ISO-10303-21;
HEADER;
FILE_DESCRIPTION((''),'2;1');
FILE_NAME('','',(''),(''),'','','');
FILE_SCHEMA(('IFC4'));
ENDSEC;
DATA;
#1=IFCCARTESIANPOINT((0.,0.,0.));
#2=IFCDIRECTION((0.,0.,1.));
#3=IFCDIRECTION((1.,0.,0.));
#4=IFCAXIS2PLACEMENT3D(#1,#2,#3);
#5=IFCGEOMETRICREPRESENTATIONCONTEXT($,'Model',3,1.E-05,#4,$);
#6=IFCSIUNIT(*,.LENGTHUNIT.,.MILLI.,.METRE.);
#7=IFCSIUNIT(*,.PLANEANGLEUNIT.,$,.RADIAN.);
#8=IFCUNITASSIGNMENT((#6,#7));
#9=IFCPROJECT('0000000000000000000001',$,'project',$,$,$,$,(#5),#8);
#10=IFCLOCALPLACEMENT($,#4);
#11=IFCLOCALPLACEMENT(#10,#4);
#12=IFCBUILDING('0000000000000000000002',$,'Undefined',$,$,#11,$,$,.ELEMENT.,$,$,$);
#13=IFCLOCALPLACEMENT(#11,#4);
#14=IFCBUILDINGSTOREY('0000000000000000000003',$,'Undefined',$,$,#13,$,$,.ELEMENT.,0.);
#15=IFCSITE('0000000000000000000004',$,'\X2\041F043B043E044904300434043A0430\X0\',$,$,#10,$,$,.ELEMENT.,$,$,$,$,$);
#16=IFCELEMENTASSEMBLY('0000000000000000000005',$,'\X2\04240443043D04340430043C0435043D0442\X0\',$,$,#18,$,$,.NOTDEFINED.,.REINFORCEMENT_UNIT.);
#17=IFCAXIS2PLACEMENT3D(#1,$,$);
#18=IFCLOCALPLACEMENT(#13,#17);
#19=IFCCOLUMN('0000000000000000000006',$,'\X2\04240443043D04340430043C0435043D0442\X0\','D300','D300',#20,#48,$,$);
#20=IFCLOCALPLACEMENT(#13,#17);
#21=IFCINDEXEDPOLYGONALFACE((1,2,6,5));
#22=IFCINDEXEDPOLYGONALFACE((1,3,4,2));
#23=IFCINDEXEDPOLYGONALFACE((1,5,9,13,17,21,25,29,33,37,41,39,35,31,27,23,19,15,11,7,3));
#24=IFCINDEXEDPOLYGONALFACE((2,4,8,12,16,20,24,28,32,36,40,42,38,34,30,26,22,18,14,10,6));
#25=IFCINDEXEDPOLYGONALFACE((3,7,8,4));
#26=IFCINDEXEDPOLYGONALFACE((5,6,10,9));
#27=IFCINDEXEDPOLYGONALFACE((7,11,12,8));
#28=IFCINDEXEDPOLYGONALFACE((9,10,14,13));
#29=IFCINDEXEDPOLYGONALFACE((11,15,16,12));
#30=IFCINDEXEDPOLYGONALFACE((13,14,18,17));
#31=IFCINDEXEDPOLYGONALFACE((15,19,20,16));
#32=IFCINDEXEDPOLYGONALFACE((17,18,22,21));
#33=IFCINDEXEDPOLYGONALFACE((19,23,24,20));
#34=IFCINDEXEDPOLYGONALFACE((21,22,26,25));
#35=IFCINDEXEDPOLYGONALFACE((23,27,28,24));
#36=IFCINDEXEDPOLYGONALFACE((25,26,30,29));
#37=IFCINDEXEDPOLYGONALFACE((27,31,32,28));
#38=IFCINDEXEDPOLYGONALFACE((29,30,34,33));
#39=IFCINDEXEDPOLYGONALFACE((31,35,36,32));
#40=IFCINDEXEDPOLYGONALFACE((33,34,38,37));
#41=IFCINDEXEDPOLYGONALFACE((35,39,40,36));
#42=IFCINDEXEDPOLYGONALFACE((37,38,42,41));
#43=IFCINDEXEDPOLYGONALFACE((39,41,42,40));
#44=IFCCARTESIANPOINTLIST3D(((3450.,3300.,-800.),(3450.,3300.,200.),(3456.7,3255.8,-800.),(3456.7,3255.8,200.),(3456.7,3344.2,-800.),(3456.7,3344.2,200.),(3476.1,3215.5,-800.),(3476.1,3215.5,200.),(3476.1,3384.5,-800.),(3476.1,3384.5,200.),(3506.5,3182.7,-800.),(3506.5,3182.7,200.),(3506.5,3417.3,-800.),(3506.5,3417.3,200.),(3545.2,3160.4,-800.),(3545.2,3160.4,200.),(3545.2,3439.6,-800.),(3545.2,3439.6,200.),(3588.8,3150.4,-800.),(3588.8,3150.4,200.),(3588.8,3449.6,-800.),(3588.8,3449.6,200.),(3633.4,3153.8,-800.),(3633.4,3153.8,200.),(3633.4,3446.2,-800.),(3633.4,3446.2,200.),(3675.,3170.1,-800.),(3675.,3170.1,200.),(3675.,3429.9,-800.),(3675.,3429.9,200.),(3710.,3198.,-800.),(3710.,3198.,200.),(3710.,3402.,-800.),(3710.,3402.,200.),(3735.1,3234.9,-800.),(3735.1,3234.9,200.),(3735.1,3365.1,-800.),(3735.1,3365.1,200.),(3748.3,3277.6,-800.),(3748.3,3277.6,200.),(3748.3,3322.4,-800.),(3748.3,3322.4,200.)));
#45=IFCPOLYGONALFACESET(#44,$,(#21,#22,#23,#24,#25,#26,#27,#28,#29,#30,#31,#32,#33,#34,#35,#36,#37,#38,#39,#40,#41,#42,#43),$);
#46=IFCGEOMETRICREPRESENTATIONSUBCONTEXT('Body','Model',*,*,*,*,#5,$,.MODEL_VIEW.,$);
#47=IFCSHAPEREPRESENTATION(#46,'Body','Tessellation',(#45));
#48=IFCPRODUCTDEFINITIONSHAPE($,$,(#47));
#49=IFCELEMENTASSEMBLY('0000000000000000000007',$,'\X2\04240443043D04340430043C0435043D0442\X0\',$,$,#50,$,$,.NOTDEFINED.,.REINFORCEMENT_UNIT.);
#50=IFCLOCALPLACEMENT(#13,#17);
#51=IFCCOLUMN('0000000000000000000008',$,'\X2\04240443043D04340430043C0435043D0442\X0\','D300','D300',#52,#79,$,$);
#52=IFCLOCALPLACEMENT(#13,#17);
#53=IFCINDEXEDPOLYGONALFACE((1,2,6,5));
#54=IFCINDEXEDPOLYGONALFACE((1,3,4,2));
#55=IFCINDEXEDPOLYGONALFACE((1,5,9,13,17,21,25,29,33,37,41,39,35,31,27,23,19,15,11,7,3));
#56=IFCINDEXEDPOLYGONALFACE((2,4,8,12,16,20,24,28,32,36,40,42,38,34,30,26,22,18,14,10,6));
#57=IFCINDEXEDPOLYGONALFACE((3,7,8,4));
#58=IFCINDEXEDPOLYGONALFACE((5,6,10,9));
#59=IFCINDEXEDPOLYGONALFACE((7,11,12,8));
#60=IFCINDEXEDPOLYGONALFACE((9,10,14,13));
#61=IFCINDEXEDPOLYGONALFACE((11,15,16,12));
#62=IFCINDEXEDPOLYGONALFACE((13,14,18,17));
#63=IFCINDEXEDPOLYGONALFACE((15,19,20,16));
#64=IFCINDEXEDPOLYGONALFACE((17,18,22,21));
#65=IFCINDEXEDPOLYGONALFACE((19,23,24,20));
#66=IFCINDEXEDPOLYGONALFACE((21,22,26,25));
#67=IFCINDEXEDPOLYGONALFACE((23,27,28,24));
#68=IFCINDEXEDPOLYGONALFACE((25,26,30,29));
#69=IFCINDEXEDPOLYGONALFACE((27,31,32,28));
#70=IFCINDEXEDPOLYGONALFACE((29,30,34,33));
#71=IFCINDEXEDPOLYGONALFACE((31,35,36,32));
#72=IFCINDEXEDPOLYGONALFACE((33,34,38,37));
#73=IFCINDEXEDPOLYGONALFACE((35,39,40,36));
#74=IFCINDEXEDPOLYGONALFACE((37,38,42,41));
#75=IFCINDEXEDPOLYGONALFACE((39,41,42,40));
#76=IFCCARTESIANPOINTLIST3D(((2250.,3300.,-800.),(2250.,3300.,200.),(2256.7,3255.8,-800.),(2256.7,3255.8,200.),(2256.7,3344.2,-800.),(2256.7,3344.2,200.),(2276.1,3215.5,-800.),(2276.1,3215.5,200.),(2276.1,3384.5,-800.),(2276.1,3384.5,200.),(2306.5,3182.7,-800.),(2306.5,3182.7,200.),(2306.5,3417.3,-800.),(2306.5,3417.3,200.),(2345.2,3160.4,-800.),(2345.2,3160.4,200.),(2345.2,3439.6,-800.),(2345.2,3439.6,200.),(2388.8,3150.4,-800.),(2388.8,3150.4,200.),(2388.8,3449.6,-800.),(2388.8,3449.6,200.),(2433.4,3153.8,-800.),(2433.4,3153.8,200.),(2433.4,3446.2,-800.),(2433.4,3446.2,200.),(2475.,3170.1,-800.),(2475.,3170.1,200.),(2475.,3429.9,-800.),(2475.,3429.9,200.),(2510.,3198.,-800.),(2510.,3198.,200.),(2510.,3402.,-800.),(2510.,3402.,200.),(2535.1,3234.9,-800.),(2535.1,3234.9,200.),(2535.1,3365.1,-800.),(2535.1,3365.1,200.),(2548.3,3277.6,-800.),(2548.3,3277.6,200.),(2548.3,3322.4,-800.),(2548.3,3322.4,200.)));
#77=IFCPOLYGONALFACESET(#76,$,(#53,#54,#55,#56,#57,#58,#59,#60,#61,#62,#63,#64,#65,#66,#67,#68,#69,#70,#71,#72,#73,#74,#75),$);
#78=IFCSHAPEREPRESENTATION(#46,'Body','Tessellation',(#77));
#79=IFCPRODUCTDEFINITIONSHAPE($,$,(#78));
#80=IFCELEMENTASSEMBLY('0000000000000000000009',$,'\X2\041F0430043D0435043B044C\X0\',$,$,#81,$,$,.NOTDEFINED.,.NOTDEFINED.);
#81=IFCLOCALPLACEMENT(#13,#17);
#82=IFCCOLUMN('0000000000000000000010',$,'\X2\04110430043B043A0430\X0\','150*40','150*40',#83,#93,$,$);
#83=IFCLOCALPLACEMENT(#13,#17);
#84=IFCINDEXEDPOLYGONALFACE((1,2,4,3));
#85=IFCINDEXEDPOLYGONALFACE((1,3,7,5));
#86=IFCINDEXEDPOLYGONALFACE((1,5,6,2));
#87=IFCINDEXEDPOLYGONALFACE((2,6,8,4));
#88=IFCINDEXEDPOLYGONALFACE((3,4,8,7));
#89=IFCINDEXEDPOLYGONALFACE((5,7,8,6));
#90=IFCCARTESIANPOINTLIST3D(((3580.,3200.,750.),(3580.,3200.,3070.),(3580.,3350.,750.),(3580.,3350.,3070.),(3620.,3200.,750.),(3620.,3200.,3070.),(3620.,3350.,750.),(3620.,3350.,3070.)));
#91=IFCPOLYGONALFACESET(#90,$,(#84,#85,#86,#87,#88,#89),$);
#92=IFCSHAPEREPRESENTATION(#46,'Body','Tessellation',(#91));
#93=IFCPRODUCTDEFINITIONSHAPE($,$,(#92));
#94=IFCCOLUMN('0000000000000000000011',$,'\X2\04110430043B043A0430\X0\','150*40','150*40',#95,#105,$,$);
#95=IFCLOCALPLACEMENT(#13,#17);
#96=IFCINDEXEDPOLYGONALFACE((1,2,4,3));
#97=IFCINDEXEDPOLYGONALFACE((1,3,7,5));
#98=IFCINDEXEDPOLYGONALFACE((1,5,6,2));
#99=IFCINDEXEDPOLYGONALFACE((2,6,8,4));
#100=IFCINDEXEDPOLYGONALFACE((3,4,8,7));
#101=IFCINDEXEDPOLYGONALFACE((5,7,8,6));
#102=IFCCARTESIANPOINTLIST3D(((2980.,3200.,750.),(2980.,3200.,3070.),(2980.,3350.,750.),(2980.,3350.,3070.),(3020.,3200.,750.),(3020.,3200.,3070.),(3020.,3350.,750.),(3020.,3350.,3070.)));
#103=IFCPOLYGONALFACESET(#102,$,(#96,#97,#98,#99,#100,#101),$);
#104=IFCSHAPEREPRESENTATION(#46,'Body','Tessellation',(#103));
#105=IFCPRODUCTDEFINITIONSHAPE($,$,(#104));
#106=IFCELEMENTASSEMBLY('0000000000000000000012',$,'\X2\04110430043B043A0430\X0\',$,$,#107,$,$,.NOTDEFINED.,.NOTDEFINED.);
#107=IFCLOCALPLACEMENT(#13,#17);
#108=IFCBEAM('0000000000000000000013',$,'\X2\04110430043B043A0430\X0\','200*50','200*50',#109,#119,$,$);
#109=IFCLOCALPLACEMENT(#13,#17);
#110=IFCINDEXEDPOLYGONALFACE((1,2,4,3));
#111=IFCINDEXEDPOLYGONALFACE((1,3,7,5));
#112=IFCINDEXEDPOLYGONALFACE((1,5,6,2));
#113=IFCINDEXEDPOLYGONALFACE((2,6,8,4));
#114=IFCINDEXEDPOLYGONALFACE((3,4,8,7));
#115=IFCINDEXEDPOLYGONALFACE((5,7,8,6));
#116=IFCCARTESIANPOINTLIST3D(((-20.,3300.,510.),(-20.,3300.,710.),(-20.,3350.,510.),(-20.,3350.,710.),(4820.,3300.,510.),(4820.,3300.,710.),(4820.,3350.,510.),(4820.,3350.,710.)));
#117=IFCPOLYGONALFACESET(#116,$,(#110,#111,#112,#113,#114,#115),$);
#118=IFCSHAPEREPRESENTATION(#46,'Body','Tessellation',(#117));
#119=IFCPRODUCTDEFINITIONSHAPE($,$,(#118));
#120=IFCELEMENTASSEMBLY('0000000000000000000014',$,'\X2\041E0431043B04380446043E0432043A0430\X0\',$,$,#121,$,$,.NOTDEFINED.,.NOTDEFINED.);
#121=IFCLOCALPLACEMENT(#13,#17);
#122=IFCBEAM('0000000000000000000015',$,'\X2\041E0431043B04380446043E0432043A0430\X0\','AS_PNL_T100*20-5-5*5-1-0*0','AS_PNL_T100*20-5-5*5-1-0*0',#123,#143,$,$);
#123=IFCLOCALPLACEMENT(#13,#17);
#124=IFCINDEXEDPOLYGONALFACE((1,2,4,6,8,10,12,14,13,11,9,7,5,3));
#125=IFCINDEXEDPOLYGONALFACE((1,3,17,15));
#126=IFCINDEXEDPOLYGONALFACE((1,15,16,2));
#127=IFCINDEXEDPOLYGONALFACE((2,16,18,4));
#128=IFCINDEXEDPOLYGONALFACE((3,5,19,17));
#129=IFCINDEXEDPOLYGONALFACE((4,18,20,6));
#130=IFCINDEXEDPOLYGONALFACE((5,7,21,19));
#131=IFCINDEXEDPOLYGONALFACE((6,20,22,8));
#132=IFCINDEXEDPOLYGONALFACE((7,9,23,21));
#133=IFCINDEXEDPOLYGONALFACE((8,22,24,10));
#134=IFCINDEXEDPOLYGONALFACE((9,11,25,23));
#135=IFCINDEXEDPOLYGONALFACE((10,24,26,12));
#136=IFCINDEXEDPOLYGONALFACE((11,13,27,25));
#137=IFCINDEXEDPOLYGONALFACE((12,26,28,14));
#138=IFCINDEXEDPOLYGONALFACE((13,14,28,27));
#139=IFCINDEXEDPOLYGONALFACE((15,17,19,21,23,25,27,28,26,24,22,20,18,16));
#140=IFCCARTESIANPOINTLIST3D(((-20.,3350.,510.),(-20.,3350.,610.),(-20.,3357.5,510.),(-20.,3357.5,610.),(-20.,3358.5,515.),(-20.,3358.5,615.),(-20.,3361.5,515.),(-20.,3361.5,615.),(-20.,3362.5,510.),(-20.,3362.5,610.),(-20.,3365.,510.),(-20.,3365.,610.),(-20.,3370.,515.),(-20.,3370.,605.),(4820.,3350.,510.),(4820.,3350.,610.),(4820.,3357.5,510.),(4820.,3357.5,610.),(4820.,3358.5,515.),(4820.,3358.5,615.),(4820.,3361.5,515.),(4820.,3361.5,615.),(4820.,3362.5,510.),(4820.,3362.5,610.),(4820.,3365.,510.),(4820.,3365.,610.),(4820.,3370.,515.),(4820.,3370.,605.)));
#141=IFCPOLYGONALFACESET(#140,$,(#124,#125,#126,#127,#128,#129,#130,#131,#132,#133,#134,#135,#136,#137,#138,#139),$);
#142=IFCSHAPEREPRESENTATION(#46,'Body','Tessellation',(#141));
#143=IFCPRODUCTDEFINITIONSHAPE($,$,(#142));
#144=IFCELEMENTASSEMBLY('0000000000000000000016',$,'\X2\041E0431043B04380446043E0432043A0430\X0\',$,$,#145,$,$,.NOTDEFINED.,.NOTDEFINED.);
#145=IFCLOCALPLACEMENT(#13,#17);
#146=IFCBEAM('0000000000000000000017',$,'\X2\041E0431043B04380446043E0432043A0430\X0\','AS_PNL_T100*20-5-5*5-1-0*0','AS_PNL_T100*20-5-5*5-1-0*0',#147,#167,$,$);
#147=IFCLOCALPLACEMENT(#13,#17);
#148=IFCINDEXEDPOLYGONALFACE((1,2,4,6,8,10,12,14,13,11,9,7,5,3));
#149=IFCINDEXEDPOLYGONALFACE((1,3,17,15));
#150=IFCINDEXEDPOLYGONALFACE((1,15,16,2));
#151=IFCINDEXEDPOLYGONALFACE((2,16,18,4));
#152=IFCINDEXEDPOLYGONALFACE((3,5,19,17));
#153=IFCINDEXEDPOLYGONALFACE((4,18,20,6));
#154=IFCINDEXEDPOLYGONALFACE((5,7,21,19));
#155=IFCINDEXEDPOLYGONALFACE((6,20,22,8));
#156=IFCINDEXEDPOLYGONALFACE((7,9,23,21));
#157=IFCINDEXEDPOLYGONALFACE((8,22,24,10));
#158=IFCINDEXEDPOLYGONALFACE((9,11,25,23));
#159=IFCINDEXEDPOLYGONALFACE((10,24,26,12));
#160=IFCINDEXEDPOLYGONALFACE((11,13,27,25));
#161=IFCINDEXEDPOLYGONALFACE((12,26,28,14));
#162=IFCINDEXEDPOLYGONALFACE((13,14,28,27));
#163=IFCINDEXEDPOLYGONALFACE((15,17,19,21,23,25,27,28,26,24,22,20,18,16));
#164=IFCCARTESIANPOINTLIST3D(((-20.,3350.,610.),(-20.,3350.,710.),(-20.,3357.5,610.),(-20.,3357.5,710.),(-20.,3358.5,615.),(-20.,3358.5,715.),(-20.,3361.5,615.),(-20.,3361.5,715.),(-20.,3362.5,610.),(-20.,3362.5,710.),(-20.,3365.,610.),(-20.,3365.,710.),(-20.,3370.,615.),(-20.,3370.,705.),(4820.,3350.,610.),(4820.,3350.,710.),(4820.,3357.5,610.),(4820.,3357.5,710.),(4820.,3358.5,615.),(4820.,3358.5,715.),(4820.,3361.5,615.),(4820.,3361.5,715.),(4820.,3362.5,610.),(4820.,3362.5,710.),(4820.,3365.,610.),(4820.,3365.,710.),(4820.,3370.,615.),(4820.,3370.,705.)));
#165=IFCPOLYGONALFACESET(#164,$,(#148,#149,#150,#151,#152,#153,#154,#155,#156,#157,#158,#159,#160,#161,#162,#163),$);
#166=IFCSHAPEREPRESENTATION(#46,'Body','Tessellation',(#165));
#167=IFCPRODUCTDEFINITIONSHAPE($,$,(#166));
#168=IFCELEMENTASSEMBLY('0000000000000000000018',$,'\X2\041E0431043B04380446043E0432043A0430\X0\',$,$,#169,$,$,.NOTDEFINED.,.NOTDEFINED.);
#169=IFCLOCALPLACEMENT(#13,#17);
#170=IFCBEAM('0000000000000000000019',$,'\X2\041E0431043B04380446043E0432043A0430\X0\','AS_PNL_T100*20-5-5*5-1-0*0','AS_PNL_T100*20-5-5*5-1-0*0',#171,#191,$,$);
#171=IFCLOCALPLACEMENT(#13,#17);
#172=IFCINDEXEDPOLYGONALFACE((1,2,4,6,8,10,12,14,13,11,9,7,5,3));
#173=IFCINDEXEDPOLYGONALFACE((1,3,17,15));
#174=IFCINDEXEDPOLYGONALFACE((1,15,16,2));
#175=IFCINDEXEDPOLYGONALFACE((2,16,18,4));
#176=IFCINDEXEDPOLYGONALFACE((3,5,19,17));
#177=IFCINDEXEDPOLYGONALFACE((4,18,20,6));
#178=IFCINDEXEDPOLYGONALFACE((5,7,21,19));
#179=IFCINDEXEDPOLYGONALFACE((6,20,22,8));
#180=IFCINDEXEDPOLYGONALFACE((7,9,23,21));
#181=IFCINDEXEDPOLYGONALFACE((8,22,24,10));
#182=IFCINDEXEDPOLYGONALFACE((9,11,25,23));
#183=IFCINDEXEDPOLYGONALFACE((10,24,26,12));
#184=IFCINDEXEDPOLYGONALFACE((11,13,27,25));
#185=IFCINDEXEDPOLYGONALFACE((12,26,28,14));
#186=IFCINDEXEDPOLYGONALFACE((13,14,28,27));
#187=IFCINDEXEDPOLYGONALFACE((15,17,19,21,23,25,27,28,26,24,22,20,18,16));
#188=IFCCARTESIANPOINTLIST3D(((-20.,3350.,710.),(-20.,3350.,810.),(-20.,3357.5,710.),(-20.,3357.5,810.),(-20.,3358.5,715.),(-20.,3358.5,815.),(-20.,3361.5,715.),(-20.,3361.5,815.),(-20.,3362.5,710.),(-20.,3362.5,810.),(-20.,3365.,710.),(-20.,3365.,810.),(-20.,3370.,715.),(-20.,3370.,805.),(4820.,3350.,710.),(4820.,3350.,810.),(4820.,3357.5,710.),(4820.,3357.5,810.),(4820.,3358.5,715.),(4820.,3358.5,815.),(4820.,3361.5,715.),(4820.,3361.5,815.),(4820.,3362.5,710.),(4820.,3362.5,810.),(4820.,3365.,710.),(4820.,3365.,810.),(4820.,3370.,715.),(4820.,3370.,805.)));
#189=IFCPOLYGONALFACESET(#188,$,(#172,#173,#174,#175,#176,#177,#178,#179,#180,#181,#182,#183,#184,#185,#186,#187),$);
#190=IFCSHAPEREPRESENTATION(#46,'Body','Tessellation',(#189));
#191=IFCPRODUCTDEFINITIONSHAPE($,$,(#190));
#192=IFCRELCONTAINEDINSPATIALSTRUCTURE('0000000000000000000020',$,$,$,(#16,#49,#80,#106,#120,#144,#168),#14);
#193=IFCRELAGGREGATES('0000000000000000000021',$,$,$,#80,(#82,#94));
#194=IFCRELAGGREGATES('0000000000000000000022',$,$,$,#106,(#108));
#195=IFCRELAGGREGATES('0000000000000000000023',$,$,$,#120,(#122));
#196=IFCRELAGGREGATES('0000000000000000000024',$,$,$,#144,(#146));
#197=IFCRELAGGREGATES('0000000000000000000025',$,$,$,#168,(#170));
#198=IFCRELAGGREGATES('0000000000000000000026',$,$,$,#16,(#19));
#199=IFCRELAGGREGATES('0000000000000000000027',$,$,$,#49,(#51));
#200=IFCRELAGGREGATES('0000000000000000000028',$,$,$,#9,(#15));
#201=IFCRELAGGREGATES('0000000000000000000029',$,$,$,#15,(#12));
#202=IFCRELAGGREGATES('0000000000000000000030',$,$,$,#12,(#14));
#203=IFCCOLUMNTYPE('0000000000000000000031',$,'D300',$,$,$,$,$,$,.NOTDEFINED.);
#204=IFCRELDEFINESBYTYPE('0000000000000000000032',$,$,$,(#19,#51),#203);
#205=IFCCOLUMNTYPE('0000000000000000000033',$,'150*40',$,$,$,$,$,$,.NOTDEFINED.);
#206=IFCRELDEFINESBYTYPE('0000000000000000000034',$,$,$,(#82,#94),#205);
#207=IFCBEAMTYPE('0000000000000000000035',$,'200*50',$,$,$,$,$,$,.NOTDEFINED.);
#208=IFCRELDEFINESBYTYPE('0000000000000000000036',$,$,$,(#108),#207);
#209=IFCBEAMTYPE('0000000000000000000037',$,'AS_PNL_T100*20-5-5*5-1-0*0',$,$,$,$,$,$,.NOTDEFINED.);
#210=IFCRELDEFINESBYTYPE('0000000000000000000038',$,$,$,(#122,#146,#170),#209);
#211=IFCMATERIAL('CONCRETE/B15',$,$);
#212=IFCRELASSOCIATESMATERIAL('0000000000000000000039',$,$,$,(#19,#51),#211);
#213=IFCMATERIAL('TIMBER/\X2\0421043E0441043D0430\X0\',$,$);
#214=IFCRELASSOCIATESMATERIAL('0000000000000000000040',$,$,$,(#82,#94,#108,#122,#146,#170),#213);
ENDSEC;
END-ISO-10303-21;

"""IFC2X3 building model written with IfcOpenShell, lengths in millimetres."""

from ifc_helpers import new_model, si_unit, frame, origin_with_axes, origin_2d_with_axis, place, context, subcontext, project, spatial, polyline, rectangle, circle, outline, extrude, material, type_object, element, aggregate, save


model = new_model("IFC2X3")

# Units and contexts
model_context = context("Model", 3, precision=1e-05, world=origin_with_axes())
body_context = subcontext(model_context, "Body", "Model", "MODEL_VIEW")
ifc_project = project(units=[si_unit("LENGTHUNIT", "METRE", prefix="MILLI"), si_unit("PLANEANGLEUNIT", "RADIAN")], contexts=[model_context])

# Site, building, storey
site_placement = place(None, origin_with_axes())
site = spatial("IfcSite", under=ifc_project, at=site_placement, Name="Площадка", CompositionType="ELEMENT")
building_placement = place(site_placement, origin_with_axes())
building = spatial("IfcBuilding", under=site, at=building_placement, Name="Undefined", CompositionType="ELEMENT")
storey_placement = place(building_placement, origin_with_axes())
storey = spatial("IfcBuildingStorey", under=building, at=storey_placement, Name="Undefined", CompositionType="ELEMENT", Elevation=0.0)

# Element assemblies, columns
ifc_material_1 = material(Name="CONCRETE/B15")
column_type_1 = type_object("IfcColumnType", Name="D300", PredefinedType="NOTDEFINED")
assembly_1_placement = place(storey_placement, origin_with_axes())
assembly_1 = element("IfcElementAssembly", 1, at=assembly_1_placement, inside=storey, Name="Фундамент", AssemblyPlace="NOTDEFINED", PredefinedType="REINFORCEMENT_UNIT")
column_1_placement = place(assembly_1_placement, frame((3600.0, 3300.0, -800.0), z_axis=(0.0, 0.0, 1.0), x_axis=(0.0, 1.0, 0.0)))
column_1 = element("IfcColumn", 2, at=column_1_placement, type_object=column_type_1, material=ifc_material_1, Name="Фундамент", Description="D300", ObjectType="D300", context=body_context, shape_type="SweptSolid", body=[
    extrude(circle(Radius=150.0, at=origin_2d_with_axis()), frame((0.0, 0.0, 1000.0), z_axis=(0.0, 0.0, -1.0), x_axis=(0.0, 1.0, 0.0)), (0.0, 0.0, 1.0), 1000.0),
])
assembly_2_placement = place(storey_placement, origin_with_axes())
assembly_2 = element("IfcElementAssembly", 3, at=assembly_2_placement, inside=storey, Name="Фундамент", AssemblyPlace="NOTDEFINED", PredefinedType="REINFORCEMENT_UNIT")
column_2_placement = place(assembly_2_placement, frame((2400.0, 3300.0, -800.0), z_axis=(0.0, 0.0, 1.0), x_axis=(0.0, 1.0, 0.0)))
column_2 = element("IfcColumn", 4, at=column_2_placement, type_object=column_type_1, material=ifc_material_1, Name="Фундамент", Description="D300", ObjectType="D300", context=body_context, shape_type="SweptSolid", body=[
    extrude(circle(Radius=150.0, at=origin_2d_with_axis()), frame((0.0, 0.0, 1000.0), z_axis=(0.0, 0.0, -1.0), x_axis=(0.0, 1.0, 0.0)), (0.0, 0.0, 1.0), 1000.0),
])

# Element assembly, columns
assembly_3_placement = place(storey_placement, origin_with_axes())
assembly_3 = element("IfcElementAssembly", 5, at=assembly_3_placement, inside=storey, Name="Панель", AssemblyPlace="NOTDEFINED", PredefinedType="NOTDEFINED")
ifc_material_2 = material(Name="TIMBER/Сосна")
column_type_2 = type_object("IfcColumnType", Name="150*40", PredefinedType="NOTDEFINED")
column_3_placement = place(assembly_3_placement, frame((3600.0, 3275.0, 750.0), z_axis=(0.0, 0.0, 1.0), x_axis=(0.0, 1.0, 0.0)))
column_3 = element("IfcColumn", 6, at=column_3_placement, type_object=column_type_2, material=ifc_material_2, Name="Балка", Description="150*40", ObjectType="150*40", context=body_context, shape_type="SweptSolid", body=[
    extrude(rectangle(XDim=40.0, YDim=150.0, at=origin_2d_with_axis()), frame((0.0, 0.0, 2320.0), z_axis=(0.0, 0.0, -1.0), x_axis=(0.0, 1.0, 0.0)), (0.0, 0.0, 1.0), 2320.0),
])
column_4_placement = place(assembly_3_placement, frame((3000.0, 3275.0, 750.0), z_axis=(0.0, 0.0, 1.0), x_axis=(0.0, 1.0, 0.0)))
column_4 = element("IfcColumn", 7, at=column_4_placement, type_object=column_type_2, material=ifc_material_2, Name="Балка", Description="150*40", ObjectType="150*40", context=body_context, shape_type="SweptSolid", body=[
    extrude(rectangle(XDim=40.0, YDim=150.0, at=origin_2d_with_axis()), frame((0.0, 0.0, 2320.0), z_axis=(0.0, 0.0, -1.0), x_axis=(0.0, 1.0, 0.0)), (0.0, 0.0, 1.0), 2320.0),
])
aggregate(assembly_3, [column_3, column_4])

# Element assemblies, beams
assembly_4_placement = place(storey_placement, origin_with_axes())
assembly_4 = element("IfcElementAssembly", 8, at=assembly_4_placement, inside=storey, Name="Балка", AssemblyPlace="NOTDEFINED", PredefinedType="NOTDEFINED")
beam_type_1 = type_object("IfcBeamType", Name="200*50", PredefinedType="NOTDEFINED")
beam_1_placement = place(assembly_4_placement, frame((4820.0, 3325.0, 610.0), z_axis=(0.0, 0.0, -1.0), x_axis=(-1.0, 0.0, 0.0)))
beam_1 = element("IfcBeam", 9, at=beam_1_placement, type_object=beam_type_1, material=ifc_material_2, Name="Балка", Description="200*50", ObjectType="200*50", context=body_context, shape_type="SweptSolid", body=[
    extrude(rectangle(XDim=50.0, YDim=200.0, at=origin_2d_with_axis()), frame((4840.0, 0.0, 0.0), z_axis=(-1.0, 0.0, 0.0), x_axis=(0.0, -1.0, 0.0)), (0.0, 0.0, 1.0), 4840.0),
])
aggregate(assembly_4, [beam_1])
assembly_5_placement = place(storey_placement, origin_with_axes())
assembly_5 = element("IfcElementAssembly", 10, at=assembly_5_placement, inside=storey, Name="Облицовка", AssemblyPlace="NOTDEFINED", PredefinedType="NOTDEFINED")
beam_type_2 = type_object("IfcBeamType", Name="AS_PNL_T100*20-5-5*5-1-0*0", PredefinedType="NOTDEFINED")
beam_2_placement = place(assembly_5_placement, frame((4820.0, 3360.0, 560.0), z_axis=(0.0, 0.0, 1.0), x_axis=(-1.0, 0.0, 0.0)))
beam_2 = element("IfcBeam", 11, at=beam_2_placement, type_object=beam_type_2, material=ifc_material_2, Name="Облицовка", Description="AS_PNL_T100*20-5-5*5-1-0*0", ObjectType="AS_PNL_T100*20-5-5*5-1-0*0", context=body_context, shape_type="SweptSolid", body=[
    extrude(outline(polyline([(-2.5, -50.0), (-10.0, -50.0), (-10.0, 50.0), (-2.5, 50.0), (-1.5, 55.0), (1.5, 55.0), (2.5, 50.0), (5.0, 50.0), (10.0, 45.0), (10.0, -45.0), (5.0, -50.0), (2.5, -50.0), (1.5, -45.0), (-1.5, -45.0), (-2.5, -50.0)])), frame((4840.0, 0.0, 0.0), z_axis=(-1.0, 0.0, 0.0), x_axis=(0.0, -1.0, 0.0)), (0.0, 0.0, 1.0), 4840.0),
])
aggregate(assembly_5, [beam_2])
assembly_6_placement = place(storey_placement, origin_with_axes())
assembly_6 = element("IfcElementAssembly", 12, at=assembly_6_placement, inside=storey, Name="Облицовка", AssemblyPlace="NOTDEFINED", PredefinedType="NOTDEFINED")
beam_3_placement = place(assembly_6_placement, frame((4820.0, 3360.0, 660.0), z_axis=(0.0, 0.0, 1.0), x_axis=(-1.0, 0.0, 0.0)))
beam_3 = element("IfcBeam", 13, at=beam_3_placement, type_object=beam_type_2, material=ifc_material_2, Name="Облицовка", Description="AS_PNL_T100*20-5-5*5-1-0*0", ObjectType="AS_PNL_T100*20-5-5*5-1-0*0", context=body_context, shape_type="SweptSolid", body=[
    extrude(outline(polyline([(-2.5, -50.0), (-10.0, -50.0), (-10.0, 50.0), (-2.5, 50.0), (-1.5, 55.0), (1.5, 55.0), (2.5, 50.0), (5.0, 50.0), (10.0, 45.0), (10.0, -45.0), (5.0, -50.0), (2.5, -50.0), (1.5, -45.0), (-1.5, -45.0), (-2.5, -50.0)])), frame((4840.0, 0.0, 0.0), z_axis=(-1.0, 0.0, 0.0), x_axis=(0.0, -1.0, 0.0)), (0.0, 0.0, 1.0), 4840.0),
])
aggregate(assembly_6, [beam_3])
assembly_7_placement = place(storey_placement, origin_with_axes())
assembly_7 = element("IfcElementAssembly", 14, at=assembly_7_placement, inside=storey, Name="Облицовка", AssemblyPlace="NOTDEFINED", PredefinedType="NOTDEFINED")
beam_4_placement = place(assembly_7_placement, frame((4820.0, 3360.0, 760.0), z_axis=(0.0, 0.0, 1.0), x_axis=(-1.0, 0.0, 0.0)))
beam_4 = element("IfcBeam", 15, at=beam_4_placement, type_object=beam_type_2, material=ifc_material_2, Name="Облицовка", Description="AS_PNL_T100*20-5-5*5-1-0*0", ObjectType="AS_PNL_T100*20-5-5*5-1-0*0", context=body_context, shape_type="SweptSolid", body=[
    extrude(outline(polyline([(-2.5, -50.0), (-10.0, -50.0), (-10.0, 50.0), (-2.5, 50.0), (-1.5, 55.0), (1.5, 55.0), (2.5, 50.0), (5.0, 50.0), (10.0, 45.0), (10.0, -45.0), (5.0, -50.0), (2.5, -50.0), (1.5, -45.0), (-1.5, -45.0), (-2.5, -50.0)])), frame((4840.0, 0.0, 0.0), z_axis=(-1.0, 0.0, 0.0), x_axis=(0.0, -1.0, 0.0)), (0.0, 0.0, 1.0), 4840.0),
])
aggregate(assembly_7, [beam_4])

aggregate(assembly_1, [column_1])
aggregate(assembly_2, [column_2])

save(model, "model.ifc")
